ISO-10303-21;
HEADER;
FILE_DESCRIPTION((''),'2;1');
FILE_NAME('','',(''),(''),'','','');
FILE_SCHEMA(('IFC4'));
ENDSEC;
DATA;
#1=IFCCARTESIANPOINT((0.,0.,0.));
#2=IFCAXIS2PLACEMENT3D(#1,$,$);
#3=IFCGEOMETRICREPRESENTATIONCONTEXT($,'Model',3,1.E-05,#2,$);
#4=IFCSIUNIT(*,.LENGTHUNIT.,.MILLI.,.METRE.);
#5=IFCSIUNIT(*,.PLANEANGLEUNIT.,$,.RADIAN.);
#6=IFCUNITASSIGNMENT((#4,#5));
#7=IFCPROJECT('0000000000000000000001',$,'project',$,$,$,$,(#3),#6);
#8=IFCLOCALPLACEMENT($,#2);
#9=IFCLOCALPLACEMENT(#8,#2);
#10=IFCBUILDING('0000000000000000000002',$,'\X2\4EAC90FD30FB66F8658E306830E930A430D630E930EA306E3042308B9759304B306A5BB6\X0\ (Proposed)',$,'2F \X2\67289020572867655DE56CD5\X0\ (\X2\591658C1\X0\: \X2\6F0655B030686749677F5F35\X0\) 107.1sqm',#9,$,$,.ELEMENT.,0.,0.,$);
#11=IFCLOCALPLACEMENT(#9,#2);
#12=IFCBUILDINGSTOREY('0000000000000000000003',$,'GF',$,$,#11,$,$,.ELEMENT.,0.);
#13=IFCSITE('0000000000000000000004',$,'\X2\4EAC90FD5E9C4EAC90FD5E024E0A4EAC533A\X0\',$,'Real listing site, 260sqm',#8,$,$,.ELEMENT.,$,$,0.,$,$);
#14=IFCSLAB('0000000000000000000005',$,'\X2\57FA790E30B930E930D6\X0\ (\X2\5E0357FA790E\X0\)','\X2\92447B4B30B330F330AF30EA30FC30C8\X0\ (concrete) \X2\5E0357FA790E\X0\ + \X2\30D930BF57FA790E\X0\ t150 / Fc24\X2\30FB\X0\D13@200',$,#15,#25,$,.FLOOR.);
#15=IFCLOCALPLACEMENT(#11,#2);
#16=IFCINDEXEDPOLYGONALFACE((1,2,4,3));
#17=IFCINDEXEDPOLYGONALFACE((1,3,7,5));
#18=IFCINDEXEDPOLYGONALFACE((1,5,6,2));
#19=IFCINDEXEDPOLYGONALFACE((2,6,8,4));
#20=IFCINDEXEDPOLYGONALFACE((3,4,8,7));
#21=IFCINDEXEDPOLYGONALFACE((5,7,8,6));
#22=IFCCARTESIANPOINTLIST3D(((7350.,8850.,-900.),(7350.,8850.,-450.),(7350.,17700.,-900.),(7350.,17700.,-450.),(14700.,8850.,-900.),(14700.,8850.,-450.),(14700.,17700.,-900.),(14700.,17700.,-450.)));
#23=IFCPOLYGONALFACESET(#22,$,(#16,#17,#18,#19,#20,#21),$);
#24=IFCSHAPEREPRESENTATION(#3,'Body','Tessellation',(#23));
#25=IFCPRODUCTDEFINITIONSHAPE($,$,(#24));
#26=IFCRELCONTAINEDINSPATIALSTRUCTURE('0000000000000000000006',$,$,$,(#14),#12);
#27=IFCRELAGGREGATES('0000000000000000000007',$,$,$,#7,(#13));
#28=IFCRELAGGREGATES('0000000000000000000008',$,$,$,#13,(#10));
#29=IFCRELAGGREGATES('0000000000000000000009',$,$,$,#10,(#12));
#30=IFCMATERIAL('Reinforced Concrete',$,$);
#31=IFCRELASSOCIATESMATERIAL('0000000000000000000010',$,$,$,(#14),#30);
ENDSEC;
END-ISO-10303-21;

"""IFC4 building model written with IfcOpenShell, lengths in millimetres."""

from ifc_helpers import new_model, si_unit, frame, frame_2d, origin, place, context, project, spatial, rectangle, extrude, material, element, save


model = new_model("IFC4")

# Units and contexts
model_context = context("Model", 3, precision=1e-05, world=origin())
ifc_project = project(units=[si_unit("LENGTHUNIT", "METRE", prefix="MILLI"), si_unit("PLANEANGLEUNIT", "RADIAN")], contexts=[model_context])

# Site, building, storey
site_placement = place(None, origin())
site = spatial("IfcSite", under=ifc_project, at=site_placement, Name="京都府京都市上京区", ObjectType="Real listing site, 260sqm", CompositionType="ELEMENT", RefElevation=0.0)
building_placement = place(site_placement, origin())
building = spatial("IfcBuilding", under=site, at=building_placement, Name="京都・書斎とライブラリのある静かな家 (Proposed)", ObjectType="2F 木造在来工法 (外壁: 漆喰と杉板張) 107.1sqm", CompositionType="ELEMENT", ElevationOfRefHeight=0.0, ElevationOfTerrain=0.0)
storey_placement = place(building_placement, origin())
storey = spatial("IfcBuildingStorey", under=building, at=storey_placement, Name="GF", CompositionType="ELEMENT", Elevation=0.0)

# Slab
ifc_material_1 = material(Name="Reinforced Concrete")
slab_1_placement = place(storey_placement, frame((3675.0, 4425.0, -450.0)))
element("IfcSlab", 1, at=slab_1_placement, inside=storey, material=ifc_material_1, Name="基礎スラブ (布基礎)", Description="鉄筋コンクリート (concrete) 布基礎 + ベタ基礎 t150 / Fc24・D13@200", PredefinedType="FLOOR", context=model_context, shape_type="SweptSolid", body=[
    extrude(rectangle(XDim=7350.0, YDim=8850.0, at=frame_2d((3675.0, 4425.0))), frame((3675.0, 4425.0, -450.0)), (0.0, 0.0, 1.0), 450.0),
])

save(model, "model.ifc")
